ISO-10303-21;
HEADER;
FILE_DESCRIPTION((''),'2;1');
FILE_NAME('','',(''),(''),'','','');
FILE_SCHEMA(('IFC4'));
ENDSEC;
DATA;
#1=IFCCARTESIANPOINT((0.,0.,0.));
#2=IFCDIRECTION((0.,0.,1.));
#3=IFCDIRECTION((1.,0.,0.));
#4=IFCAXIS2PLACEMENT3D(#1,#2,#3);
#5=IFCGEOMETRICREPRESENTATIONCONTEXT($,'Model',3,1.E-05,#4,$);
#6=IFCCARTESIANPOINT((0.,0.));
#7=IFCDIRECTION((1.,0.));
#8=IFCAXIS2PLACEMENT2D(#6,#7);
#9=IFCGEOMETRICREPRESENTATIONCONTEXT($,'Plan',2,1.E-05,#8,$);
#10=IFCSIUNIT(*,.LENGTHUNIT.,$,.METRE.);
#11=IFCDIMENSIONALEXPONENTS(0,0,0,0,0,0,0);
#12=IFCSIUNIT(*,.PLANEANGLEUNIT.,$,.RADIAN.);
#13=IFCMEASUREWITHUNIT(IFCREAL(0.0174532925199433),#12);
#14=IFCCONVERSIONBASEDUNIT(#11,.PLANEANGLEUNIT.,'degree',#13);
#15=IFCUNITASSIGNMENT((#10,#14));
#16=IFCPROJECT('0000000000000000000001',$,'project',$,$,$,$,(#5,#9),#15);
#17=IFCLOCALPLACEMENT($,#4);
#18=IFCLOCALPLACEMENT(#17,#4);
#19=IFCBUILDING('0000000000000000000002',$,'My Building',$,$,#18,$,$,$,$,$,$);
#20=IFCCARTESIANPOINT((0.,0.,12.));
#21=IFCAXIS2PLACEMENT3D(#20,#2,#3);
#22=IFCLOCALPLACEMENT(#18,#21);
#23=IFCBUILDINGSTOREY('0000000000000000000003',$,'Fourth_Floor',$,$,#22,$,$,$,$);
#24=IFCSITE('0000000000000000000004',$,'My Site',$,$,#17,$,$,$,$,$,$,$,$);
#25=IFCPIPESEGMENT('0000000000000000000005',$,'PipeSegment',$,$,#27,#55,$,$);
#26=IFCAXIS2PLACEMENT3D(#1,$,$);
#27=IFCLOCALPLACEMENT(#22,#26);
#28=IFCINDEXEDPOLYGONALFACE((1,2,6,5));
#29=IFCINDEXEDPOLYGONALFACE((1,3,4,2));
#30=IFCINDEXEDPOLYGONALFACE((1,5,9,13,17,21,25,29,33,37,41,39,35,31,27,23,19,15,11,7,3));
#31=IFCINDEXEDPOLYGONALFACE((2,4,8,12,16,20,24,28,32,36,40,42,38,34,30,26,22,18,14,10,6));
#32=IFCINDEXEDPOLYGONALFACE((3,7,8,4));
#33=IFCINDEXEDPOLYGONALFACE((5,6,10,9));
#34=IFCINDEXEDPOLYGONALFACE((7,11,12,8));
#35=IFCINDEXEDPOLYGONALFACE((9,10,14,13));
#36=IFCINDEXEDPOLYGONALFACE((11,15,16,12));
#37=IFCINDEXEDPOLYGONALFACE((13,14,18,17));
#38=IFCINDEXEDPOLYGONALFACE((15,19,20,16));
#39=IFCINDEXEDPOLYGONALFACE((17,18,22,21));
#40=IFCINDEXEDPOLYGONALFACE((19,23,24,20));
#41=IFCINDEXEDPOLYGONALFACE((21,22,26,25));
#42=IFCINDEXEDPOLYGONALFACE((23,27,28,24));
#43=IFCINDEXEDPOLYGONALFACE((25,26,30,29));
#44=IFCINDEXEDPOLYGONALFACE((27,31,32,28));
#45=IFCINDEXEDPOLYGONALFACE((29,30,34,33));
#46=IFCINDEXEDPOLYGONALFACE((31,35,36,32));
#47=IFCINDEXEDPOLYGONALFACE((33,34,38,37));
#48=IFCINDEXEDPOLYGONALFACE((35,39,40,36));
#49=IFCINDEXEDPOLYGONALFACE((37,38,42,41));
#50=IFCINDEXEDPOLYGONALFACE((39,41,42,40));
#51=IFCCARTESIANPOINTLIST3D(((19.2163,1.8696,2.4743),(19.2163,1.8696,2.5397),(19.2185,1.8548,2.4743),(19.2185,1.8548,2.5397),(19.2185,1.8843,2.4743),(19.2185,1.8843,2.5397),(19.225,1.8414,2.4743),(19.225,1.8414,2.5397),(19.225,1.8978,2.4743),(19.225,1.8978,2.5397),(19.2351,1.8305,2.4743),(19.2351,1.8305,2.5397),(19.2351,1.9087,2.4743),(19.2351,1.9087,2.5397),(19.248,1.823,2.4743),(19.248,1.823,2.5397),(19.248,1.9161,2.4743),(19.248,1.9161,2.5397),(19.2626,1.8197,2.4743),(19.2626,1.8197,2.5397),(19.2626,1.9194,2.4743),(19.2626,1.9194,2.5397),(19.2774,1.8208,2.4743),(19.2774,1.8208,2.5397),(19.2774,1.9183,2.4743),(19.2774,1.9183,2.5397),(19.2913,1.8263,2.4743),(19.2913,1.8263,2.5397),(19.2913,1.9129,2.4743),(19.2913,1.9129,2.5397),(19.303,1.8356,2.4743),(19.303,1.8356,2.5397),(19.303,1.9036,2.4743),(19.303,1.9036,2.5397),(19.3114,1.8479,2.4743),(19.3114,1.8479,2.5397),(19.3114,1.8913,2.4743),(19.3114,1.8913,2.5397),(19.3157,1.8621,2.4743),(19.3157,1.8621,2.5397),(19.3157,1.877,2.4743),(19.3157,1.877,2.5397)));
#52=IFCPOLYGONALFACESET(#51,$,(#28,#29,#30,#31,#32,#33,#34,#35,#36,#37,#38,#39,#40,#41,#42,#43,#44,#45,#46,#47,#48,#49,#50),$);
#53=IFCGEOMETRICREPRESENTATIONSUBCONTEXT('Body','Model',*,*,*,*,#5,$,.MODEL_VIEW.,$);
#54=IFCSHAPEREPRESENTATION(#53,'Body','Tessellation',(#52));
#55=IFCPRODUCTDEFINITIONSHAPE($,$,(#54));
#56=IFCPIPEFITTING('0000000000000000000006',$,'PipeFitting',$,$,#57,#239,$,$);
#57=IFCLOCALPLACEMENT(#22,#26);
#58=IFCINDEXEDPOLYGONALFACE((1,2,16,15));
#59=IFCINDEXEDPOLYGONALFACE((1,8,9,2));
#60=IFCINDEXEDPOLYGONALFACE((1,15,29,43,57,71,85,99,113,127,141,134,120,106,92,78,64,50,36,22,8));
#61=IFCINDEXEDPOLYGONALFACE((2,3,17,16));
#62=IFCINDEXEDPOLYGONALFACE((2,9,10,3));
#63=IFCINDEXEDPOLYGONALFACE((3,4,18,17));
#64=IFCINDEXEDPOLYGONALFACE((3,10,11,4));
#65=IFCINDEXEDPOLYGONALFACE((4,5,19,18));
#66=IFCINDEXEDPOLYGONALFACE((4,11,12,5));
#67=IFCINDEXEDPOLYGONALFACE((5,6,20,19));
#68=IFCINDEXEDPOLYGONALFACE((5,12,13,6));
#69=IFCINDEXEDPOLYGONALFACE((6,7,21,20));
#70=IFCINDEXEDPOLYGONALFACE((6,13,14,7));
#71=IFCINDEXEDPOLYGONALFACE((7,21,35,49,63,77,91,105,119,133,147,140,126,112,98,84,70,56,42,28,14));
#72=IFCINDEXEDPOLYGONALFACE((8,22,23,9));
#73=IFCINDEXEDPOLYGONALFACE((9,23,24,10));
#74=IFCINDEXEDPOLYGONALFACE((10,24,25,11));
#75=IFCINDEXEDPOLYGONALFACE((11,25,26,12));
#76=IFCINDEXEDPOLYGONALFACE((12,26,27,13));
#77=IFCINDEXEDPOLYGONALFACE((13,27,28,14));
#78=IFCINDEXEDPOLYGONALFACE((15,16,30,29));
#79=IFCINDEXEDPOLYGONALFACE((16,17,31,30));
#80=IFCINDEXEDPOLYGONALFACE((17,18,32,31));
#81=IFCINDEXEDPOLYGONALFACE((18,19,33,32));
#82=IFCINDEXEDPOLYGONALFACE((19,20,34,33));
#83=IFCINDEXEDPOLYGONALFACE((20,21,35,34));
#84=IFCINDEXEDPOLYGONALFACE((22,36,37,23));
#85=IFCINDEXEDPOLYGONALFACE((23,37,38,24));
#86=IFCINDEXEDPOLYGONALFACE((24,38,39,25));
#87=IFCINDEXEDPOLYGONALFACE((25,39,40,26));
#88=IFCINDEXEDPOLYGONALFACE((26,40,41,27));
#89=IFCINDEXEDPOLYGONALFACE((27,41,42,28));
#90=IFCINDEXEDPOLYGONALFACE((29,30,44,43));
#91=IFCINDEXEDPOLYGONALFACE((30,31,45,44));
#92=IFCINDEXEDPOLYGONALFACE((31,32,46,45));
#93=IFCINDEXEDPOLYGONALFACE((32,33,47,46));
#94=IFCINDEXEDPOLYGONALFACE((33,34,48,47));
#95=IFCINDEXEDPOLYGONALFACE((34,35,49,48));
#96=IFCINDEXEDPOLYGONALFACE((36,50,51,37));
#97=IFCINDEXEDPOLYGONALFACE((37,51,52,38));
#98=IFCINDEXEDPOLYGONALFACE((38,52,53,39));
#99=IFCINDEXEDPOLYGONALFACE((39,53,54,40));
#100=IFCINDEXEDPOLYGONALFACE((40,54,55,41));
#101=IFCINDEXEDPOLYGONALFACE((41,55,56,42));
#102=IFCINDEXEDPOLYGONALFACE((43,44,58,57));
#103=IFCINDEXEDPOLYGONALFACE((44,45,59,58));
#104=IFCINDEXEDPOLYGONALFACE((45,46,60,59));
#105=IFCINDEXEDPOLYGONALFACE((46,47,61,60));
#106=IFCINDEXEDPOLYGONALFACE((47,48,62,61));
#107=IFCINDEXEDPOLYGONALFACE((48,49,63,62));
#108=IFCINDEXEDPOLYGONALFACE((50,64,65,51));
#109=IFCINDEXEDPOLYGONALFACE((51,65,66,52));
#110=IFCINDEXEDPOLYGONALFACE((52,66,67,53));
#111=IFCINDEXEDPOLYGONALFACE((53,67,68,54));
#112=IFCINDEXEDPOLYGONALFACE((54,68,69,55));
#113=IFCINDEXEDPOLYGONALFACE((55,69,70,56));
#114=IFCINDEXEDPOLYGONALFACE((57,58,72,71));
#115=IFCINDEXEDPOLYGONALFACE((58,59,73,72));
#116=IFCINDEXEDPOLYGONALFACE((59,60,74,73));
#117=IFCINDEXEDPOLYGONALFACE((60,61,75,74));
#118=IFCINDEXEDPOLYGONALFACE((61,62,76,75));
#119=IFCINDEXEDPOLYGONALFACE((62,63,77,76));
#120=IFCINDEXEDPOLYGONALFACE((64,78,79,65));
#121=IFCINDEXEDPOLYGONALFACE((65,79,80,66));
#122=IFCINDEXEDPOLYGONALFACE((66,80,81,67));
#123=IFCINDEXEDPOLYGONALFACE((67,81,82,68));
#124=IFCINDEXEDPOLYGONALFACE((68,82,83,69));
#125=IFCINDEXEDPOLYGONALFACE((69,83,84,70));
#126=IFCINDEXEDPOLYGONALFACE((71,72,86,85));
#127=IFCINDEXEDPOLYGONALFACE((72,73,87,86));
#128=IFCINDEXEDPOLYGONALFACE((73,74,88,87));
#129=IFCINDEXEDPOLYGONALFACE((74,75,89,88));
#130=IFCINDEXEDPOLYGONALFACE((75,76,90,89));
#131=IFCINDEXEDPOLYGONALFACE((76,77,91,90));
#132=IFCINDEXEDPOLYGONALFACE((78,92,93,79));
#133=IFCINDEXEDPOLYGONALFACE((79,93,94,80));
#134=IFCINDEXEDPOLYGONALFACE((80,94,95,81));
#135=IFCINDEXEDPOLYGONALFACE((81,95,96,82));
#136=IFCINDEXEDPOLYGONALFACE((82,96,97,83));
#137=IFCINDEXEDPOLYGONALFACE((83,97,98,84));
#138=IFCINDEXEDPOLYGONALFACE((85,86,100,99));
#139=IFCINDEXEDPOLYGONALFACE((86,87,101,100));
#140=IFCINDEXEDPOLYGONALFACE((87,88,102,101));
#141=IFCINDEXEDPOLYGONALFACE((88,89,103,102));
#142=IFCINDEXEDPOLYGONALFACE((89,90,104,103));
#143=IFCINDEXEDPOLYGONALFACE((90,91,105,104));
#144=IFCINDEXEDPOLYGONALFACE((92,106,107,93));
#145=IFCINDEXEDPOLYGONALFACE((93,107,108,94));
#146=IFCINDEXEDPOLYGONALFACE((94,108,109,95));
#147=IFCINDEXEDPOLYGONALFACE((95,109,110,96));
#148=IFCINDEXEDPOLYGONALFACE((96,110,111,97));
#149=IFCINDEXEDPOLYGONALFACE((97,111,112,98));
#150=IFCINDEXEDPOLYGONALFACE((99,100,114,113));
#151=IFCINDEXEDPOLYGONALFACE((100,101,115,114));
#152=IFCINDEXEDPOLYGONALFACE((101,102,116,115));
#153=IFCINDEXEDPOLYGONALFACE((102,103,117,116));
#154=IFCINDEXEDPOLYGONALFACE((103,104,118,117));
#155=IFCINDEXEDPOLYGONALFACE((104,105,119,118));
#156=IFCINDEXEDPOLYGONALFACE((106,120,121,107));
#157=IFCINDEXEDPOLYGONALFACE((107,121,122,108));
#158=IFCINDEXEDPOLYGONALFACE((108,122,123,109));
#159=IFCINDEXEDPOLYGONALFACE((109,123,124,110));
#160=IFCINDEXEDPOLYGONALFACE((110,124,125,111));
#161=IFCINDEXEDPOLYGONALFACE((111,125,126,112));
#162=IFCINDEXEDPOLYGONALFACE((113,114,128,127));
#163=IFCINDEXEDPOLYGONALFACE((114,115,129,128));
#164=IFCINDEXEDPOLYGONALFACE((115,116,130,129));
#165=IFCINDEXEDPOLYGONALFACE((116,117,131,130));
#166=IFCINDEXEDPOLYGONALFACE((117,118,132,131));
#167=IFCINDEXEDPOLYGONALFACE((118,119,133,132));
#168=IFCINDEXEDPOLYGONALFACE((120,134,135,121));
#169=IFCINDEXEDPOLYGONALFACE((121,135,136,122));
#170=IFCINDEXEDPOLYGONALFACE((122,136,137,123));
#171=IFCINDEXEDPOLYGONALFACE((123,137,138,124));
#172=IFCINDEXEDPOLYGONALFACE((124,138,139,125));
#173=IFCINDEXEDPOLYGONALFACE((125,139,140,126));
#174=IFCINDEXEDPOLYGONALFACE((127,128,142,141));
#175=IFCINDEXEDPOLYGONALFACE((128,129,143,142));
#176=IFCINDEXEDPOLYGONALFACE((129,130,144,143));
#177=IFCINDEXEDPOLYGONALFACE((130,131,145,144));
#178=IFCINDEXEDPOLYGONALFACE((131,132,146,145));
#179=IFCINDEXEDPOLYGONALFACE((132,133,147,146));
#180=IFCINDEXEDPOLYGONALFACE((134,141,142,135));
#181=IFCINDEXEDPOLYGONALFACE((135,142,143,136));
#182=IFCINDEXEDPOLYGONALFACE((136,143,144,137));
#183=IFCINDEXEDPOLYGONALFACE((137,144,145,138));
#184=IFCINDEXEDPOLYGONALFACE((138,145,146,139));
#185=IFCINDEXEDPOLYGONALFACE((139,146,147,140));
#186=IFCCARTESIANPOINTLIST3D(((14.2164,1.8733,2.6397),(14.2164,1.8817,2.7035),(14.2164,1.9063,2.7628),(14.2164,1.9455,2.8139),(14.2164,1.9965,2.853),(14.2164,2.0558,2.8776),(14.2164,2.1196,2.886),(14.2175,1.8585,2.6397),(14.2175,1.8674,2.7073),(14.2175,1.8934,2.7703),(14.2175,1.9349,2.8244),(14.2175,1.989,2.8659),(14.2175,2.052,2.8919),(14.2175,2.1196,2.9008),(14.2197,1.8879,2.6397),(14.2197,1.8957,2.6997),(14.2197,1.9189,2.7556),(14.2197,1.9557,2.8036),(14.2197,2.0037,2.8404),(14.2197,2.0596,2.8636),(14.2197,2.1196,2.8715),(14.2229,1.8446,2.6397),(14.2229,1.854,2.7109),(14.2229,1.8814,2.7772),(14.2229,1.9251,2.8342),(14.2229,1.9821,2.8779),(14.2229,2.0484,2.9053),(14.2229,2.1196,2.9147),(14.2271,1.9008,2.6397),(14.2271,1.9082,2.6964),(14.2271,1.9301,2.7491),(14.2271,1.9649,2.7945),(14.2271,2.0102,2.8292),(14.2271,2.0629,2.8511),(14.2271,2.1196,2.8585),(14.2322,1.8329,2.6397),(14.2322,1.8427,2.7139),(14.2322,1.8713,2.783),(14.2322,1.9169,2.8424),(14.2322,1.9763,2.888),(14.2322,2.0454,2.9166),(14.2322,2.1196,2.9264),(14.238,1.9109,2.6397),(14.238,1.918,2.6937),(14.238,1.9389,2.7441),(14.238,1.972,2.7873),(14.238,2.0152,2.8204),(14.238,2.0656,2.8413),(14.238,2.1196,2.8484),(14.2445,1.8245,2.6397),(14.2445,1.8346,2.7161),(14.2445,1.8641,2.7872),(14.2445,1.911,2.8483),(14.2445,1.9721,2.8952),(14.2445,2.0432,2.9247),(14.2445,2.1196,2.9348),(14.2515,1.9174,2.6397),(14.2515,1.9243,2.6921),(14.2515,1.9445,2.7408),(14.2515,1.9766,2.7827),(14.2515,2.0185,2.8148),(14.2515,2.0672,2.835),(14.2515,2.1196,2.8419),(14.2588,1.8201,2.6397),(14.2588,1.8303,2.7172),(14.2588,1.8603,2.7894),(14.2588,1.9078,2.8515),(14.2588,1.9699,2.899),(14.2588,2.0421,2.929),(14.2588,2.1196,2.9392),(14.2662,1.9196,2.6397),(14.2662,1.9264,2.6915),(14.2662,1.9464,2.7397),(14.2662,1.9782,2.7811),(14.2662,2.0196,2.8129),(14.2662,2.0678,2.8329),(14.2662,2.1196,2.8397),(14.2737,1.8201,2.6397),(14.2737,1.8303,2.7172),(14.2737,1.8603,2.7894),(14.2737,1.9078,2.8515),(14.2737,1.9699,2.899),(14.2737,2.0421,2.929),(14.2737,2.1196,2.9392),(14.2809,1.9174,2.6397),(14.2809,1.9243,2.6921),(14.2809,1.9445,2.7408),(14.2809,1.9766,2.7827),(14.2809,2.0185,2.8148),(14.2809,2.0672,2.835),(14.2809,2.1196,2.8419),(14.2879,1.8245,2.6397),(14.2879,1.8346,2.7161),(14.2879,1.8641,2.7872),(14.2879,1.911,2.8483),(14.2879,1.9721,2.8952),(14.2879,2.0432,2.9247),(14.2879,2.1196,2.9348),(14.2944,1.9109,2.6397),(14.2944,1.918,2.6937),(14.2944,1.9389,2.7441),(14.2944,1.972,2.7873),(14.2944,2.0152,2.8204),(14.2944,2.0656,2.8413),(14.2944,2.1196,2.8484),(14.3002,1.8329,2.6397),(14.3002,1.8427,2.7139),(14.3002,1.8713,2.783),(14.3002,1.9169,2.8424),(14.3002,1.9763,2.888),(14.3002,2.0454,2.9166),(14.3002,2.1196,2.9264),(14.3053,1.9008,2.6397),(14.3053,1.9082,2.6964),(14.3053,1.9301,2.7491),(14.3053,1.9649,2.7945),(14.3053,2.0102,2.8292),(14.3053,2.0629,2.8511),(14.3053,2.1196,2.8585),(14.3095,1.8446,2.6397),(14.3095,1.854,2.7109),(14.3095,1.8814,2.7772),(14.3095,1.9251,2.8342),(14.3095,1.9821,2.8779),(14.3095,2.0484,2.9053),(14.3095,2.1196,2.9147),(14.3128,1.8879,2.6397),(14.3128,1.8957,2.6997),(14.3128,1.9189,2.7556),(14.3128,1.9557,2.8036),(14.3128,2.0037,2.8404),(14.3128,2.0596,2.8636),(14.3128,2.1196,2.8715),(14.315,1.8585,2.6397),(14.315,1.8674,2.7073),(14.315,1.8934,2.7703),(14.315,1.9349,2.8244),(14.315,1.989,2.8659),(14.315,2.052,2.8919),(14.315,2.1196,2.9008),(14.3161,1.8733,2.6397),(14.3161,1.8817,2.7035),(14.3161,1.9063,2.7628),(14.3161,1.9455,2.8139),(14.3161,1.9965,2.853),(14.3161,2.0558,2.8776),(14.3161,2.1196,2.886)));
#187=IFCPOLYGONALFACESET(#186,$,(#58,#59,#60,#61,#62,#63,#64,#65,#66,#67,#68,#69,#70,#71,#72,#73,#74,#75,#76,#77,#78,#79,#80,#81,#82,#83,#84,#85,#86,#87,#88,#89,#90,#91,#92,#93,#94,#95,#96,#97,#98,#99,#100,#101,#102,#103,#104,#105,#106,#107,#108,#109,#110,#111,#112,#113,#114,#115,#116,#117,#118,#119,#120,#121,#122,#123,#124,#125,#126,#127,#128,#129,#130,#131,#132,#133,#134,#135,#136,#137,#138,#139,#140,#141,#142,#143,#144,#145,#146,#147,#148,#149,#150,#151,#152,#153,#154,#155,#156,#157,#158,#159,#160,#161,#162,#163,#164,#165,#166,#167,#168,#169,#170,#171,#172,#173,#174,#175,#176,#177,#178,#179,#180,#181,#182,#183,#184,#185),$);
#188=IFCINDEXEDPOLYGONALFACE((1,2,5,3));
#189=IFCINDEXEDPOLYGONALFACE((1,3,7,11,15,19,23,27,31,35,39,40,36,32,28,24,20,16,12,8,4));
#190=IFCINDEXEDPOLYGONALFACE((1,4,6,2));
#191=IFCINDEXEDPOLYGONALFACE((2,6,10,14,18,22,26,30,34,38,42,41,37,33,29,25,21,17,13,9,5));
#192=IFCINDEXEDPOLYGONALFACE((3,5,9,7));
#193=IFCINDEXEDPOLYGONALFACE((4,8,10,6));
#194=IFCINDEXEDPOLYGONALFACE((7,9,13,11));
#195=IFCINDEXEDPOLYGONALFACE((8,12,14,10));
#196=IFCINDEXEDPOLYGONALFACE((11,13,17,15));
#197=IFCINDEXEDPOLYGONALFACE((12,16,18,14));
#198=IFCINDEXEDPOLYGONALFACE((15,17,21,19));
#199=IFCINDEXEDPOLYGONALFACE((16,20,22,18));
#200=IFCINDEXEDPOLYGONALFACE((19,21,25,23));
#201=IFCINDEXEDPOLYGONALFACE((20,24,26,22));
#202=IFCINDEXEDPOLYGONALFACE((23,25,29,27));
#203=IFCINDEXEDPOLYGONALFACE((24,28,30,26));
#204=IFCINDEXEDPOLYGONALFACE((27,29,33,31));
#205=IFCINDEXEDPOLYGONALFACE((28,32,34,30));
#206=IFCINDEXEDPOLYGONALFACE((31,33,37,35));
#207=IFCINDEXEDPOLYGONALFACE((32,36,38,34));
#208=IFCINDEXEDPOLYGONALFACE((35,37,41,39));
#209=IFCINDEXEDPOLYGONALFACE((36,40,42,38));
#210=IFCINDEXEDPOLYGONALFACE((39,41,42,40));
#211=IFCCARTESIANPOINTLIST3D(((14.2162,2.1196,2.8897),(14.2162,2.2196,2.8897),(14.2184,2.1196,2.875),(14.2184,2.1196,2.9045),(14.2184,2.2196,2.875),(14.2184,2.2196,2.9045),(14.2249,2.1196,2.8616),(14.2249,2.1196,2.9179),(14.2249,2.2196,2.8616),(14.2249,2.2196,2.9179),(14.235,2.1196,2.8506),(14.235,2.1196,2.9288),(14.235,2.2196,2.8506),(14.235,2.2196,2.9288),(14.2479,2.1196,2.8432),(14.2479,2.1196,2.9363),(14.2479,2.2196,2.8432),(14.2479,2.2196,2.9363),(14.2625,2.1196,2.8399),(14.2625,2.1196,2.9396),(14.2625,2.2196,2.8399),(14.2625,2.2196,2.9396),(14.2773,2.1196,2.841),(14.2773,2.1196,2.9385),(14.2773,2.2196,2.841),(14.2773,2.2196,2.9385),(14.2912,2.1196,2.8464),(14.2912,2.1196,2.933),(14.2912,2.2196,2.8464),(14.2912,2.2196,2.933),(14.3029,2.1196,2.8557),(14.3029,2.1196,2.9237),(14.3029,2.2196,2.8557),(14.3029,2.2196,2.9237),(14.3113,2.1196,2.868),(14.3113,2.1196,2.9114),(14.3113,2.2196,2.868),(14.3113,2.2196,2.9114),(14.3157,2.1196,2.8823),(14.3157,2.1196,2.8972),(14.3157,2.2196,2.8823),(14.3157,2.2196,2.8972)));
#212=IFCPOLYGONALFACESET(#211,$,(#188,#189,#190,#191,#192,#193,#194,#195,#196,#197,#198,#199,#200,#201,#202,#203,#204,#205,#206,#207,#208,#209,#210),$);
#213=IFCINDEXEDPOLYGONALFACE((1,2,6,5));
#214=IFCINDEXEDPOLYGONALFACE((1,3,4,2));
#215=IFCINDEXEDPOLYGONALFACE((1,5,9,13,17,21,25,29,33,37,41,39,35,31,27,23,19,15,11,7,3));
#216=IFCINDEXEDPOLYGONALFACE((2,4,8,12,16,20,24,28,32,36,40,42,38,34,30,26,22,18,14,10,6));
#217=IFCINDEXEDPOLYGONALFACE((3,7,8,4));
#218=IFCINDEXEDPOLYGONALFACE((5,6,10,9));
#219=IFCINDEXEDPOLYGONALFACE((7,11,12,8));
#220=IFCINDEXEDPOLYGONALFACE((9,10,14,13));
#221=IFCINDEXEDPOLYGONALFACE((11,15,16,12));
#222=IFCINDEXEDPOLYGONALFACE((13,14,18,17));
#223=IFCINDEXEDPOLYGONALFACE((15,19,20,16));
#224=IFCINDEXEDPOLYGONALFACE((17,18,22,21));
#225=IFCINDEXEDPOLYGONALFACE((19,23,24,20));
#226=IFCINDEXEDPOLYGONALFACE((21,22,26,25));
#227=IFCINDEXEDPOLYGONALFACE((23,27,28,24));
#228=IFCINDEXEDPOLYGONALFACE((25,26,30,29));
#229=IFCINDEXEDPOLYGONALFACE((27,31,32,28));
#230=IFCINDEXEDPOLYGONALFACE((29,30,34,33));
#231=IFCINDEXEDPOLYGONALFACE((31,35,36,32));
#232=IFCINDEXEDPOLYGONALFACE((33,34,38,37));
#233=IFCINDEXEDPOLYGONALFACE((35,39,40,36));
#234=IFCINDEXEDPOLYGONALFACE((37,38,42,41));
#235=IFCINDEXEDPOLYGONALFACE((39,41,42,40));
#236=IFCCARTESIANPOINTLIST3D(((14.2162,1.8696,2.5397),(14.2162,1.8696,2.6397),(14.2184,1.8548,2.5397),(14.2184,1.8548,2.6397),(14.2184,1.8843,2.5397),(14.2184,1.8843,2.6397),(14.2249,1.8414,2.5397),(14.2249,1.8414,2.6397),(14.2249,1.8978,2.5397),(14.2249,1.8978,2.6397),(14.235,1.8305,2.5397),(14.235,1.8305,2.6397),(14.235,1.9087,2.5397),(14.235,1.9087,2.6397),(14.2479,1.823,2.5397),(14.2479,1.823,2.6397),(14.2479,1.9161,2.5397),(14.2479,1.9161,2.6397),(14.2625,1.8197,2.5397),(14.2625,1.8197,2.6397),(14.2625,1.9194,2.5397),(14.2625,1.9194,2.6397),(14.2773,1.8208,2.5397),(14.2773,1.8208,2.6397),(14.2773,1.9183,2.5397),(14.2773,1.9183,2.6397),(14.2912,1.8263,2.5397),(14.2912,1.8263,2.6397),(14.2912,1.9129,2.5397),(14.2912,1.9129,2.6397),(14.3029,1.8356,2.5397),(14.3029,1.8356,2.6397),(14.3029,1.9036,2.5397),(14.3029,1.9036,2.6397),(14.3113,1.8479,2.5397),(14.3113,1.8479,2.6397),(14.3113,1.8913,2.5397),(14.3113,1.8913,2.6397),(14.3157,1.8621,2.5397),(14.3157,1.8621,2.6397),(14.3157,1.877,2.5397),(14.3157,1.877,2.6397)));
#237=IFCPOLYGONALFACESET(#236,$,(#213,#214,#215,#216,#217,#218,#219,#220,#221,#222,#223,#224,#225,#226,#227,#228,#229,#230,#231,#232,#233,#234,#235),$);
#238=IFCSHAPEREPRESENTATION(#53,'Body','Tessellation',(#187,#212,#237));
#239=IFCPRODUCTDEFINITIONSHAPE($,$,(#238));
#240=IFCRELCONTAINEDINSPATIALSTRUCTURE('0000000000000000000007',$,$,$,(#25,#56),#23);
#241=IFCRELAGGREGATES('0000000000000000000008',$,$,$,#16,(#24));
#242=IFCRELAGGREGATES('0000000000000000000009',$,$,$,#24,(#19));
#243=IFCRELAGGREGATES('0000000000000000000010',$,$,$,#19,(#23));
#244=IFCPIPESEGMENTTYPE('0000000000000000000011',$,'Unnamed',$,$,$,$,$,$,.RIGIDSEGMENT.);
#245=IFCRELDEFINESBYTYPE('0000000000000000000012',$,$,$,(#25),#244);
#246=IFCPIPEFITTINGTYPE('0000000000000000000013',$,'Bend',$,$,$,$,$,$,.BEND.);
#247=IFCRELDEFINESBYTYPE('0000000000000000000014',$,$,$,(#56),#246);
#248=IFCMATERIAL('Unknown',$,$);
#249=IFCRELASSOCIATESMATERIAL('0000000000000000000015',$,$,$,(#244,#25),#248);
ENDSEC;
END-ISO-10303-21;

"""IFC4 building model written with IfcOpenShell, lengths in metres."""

from ifc_helpers import new_model, entity, si_unit, converted_unit, frame, origin_with_axes, origin_2d_with_axis, place, context, subcontext, project, spatial, circle, extrude, source, transform, mapped, material, material_profile, profile_set, profile_usage, type_object, type_shapes, element, save


model = new_model("IFC4")

# Units and contexts
model_context = context("Model", 3, precision=1e-05, world=origin_with_axes())
plan_context = context("Plan", 2, precision=1e-05, world=origin_2d_with_axis())
body_context_1 = subcontext(model_context, "Body", "Model", "MODEL_VIEW")
ifc_project = project(units=[si_unit("LENGTHUNIT", "METRE"), converted_unit("PLANEANGLEUNIT", "degree", entity("IfcReal", 0.0174532925199433), si_unit("PLANEANGLEUNIT", "RADIAN"), dimensions=[0, 0, 0, 0, 0, 0, 0])], contexts=[model_context, plan_context])

# Site, building, storey
site_placement = place(None, origin_with_axes())
site = spatial("IfcSite", under=ifc_project, at=site_placement, Name="My Site")
building_placement = place(site_placement, origin_with_axes())
building = spatial("IfcBuilding", under=site, at=building_placement, Name="My Building")
storey_placement = place(building_placement, frame((0.0, 0.0, 12.0), z_axis=(0.0, 0.0, 1.0), x_axis=(1.0, 0.0, 0.0)))
storey = spatial("IfcBuildingStorey", under=building, at=storey_placement, Name="Fourth_Floor")

# Shared definitions
ifc_material = material(Name="Unknown")

# Pipe segment
ifc_material_profile_1 = material_profile(ifc_material, circle(Radius=0.05))
ifc_profile_set_1 = profile_set([ifc_material_profile_1])
pipe_segment_type = type_object("IfcPipeSegmentType", Name="Unnamed", PredefinedType="RIGIDSEGMENT", material=ifc_profile_set_1)
ifc_profile_usage_1 = profile_usage(ifc_profile_set_1, cardinal=5)
pipe_segment_1_placement = place(storey_placement, frame((19.2663, 1.8696, 2.4743), z_axis=(0.0, 0.0, 1.0), x_axis=(-1.0, 0.0, 0.0)))
element("IfcPipeSegment", 1, at=pipe_segment_1_placement, inside=storey, type_object=pipe_segment_type, material=ifc_profile_usage_1, Name="PipeSegment", context=body_context_1, shape_type="SweptSolid", body=[
    extrude(circle(Radius=0.05), origin_with_axes(), (0.0, 0.0, 1.0), 0.0654),
])

# Pipe fitting
pipe_fitting_type = type_object("IfcPipeFittingType", Name="Bend", PredefinedType="BEND")
shared_shape_1 = source(origin_with_axes(), body_context_1, "Body", "SolidModel", [
    entity("IfcSweptDiskSolid", entity("IfcIndexedPolyCurve", entity("IfcCartesianPointList3D", [[0.0, 0.0, -0.1], [0.0, -0.0732, -0.2768], [0.0, -0.25, -0.35]]), [entity("IfcArcIndex", [1, 2, 3])]), 0.05),
    extrude(circle(Radius=0.05), origin_with_axes(), (0.0, 0.0, -1.0), 0.1),
    extrude(circle(Radius=0.05), frame((0.0, -0.25, -0.35), z_axis=(0.0, -1.0, 0.0), x_axis=(1.0, 0.0, 0.0)), (0.0, 0.0, 1.0), 0.1),
])
type_shapes(pipe_fitting_type, [shared_shape_1])
for number, where, z_axis, x_axis, name in (
    (2, (14.2662, 2.2196, 2.8897), (0.0, 1.0, 0.0), (-1.0, 0.0, 0.0), "PipeFitting"),
):
    element("IfcPipeFitting", number, at=place(storey_placement, frame(where, z_axis=z_axis, x_axis=x_axis)), inside=storey, type_object=pipe_fitting_type, Name=name, context=body_context_1, shape_type="MappedRepresentation", body=[
        mapped(shared_shape_1, transform((0.0, 0.0, 0.0), x_axis=(1.0, 0.0, 0.0), y_axis=(0.0, 1.0, 0.0), z_axis=(0.0, 0.0, 1.0), scale=1.0)),
    ])

save(model, "model.ifc")
